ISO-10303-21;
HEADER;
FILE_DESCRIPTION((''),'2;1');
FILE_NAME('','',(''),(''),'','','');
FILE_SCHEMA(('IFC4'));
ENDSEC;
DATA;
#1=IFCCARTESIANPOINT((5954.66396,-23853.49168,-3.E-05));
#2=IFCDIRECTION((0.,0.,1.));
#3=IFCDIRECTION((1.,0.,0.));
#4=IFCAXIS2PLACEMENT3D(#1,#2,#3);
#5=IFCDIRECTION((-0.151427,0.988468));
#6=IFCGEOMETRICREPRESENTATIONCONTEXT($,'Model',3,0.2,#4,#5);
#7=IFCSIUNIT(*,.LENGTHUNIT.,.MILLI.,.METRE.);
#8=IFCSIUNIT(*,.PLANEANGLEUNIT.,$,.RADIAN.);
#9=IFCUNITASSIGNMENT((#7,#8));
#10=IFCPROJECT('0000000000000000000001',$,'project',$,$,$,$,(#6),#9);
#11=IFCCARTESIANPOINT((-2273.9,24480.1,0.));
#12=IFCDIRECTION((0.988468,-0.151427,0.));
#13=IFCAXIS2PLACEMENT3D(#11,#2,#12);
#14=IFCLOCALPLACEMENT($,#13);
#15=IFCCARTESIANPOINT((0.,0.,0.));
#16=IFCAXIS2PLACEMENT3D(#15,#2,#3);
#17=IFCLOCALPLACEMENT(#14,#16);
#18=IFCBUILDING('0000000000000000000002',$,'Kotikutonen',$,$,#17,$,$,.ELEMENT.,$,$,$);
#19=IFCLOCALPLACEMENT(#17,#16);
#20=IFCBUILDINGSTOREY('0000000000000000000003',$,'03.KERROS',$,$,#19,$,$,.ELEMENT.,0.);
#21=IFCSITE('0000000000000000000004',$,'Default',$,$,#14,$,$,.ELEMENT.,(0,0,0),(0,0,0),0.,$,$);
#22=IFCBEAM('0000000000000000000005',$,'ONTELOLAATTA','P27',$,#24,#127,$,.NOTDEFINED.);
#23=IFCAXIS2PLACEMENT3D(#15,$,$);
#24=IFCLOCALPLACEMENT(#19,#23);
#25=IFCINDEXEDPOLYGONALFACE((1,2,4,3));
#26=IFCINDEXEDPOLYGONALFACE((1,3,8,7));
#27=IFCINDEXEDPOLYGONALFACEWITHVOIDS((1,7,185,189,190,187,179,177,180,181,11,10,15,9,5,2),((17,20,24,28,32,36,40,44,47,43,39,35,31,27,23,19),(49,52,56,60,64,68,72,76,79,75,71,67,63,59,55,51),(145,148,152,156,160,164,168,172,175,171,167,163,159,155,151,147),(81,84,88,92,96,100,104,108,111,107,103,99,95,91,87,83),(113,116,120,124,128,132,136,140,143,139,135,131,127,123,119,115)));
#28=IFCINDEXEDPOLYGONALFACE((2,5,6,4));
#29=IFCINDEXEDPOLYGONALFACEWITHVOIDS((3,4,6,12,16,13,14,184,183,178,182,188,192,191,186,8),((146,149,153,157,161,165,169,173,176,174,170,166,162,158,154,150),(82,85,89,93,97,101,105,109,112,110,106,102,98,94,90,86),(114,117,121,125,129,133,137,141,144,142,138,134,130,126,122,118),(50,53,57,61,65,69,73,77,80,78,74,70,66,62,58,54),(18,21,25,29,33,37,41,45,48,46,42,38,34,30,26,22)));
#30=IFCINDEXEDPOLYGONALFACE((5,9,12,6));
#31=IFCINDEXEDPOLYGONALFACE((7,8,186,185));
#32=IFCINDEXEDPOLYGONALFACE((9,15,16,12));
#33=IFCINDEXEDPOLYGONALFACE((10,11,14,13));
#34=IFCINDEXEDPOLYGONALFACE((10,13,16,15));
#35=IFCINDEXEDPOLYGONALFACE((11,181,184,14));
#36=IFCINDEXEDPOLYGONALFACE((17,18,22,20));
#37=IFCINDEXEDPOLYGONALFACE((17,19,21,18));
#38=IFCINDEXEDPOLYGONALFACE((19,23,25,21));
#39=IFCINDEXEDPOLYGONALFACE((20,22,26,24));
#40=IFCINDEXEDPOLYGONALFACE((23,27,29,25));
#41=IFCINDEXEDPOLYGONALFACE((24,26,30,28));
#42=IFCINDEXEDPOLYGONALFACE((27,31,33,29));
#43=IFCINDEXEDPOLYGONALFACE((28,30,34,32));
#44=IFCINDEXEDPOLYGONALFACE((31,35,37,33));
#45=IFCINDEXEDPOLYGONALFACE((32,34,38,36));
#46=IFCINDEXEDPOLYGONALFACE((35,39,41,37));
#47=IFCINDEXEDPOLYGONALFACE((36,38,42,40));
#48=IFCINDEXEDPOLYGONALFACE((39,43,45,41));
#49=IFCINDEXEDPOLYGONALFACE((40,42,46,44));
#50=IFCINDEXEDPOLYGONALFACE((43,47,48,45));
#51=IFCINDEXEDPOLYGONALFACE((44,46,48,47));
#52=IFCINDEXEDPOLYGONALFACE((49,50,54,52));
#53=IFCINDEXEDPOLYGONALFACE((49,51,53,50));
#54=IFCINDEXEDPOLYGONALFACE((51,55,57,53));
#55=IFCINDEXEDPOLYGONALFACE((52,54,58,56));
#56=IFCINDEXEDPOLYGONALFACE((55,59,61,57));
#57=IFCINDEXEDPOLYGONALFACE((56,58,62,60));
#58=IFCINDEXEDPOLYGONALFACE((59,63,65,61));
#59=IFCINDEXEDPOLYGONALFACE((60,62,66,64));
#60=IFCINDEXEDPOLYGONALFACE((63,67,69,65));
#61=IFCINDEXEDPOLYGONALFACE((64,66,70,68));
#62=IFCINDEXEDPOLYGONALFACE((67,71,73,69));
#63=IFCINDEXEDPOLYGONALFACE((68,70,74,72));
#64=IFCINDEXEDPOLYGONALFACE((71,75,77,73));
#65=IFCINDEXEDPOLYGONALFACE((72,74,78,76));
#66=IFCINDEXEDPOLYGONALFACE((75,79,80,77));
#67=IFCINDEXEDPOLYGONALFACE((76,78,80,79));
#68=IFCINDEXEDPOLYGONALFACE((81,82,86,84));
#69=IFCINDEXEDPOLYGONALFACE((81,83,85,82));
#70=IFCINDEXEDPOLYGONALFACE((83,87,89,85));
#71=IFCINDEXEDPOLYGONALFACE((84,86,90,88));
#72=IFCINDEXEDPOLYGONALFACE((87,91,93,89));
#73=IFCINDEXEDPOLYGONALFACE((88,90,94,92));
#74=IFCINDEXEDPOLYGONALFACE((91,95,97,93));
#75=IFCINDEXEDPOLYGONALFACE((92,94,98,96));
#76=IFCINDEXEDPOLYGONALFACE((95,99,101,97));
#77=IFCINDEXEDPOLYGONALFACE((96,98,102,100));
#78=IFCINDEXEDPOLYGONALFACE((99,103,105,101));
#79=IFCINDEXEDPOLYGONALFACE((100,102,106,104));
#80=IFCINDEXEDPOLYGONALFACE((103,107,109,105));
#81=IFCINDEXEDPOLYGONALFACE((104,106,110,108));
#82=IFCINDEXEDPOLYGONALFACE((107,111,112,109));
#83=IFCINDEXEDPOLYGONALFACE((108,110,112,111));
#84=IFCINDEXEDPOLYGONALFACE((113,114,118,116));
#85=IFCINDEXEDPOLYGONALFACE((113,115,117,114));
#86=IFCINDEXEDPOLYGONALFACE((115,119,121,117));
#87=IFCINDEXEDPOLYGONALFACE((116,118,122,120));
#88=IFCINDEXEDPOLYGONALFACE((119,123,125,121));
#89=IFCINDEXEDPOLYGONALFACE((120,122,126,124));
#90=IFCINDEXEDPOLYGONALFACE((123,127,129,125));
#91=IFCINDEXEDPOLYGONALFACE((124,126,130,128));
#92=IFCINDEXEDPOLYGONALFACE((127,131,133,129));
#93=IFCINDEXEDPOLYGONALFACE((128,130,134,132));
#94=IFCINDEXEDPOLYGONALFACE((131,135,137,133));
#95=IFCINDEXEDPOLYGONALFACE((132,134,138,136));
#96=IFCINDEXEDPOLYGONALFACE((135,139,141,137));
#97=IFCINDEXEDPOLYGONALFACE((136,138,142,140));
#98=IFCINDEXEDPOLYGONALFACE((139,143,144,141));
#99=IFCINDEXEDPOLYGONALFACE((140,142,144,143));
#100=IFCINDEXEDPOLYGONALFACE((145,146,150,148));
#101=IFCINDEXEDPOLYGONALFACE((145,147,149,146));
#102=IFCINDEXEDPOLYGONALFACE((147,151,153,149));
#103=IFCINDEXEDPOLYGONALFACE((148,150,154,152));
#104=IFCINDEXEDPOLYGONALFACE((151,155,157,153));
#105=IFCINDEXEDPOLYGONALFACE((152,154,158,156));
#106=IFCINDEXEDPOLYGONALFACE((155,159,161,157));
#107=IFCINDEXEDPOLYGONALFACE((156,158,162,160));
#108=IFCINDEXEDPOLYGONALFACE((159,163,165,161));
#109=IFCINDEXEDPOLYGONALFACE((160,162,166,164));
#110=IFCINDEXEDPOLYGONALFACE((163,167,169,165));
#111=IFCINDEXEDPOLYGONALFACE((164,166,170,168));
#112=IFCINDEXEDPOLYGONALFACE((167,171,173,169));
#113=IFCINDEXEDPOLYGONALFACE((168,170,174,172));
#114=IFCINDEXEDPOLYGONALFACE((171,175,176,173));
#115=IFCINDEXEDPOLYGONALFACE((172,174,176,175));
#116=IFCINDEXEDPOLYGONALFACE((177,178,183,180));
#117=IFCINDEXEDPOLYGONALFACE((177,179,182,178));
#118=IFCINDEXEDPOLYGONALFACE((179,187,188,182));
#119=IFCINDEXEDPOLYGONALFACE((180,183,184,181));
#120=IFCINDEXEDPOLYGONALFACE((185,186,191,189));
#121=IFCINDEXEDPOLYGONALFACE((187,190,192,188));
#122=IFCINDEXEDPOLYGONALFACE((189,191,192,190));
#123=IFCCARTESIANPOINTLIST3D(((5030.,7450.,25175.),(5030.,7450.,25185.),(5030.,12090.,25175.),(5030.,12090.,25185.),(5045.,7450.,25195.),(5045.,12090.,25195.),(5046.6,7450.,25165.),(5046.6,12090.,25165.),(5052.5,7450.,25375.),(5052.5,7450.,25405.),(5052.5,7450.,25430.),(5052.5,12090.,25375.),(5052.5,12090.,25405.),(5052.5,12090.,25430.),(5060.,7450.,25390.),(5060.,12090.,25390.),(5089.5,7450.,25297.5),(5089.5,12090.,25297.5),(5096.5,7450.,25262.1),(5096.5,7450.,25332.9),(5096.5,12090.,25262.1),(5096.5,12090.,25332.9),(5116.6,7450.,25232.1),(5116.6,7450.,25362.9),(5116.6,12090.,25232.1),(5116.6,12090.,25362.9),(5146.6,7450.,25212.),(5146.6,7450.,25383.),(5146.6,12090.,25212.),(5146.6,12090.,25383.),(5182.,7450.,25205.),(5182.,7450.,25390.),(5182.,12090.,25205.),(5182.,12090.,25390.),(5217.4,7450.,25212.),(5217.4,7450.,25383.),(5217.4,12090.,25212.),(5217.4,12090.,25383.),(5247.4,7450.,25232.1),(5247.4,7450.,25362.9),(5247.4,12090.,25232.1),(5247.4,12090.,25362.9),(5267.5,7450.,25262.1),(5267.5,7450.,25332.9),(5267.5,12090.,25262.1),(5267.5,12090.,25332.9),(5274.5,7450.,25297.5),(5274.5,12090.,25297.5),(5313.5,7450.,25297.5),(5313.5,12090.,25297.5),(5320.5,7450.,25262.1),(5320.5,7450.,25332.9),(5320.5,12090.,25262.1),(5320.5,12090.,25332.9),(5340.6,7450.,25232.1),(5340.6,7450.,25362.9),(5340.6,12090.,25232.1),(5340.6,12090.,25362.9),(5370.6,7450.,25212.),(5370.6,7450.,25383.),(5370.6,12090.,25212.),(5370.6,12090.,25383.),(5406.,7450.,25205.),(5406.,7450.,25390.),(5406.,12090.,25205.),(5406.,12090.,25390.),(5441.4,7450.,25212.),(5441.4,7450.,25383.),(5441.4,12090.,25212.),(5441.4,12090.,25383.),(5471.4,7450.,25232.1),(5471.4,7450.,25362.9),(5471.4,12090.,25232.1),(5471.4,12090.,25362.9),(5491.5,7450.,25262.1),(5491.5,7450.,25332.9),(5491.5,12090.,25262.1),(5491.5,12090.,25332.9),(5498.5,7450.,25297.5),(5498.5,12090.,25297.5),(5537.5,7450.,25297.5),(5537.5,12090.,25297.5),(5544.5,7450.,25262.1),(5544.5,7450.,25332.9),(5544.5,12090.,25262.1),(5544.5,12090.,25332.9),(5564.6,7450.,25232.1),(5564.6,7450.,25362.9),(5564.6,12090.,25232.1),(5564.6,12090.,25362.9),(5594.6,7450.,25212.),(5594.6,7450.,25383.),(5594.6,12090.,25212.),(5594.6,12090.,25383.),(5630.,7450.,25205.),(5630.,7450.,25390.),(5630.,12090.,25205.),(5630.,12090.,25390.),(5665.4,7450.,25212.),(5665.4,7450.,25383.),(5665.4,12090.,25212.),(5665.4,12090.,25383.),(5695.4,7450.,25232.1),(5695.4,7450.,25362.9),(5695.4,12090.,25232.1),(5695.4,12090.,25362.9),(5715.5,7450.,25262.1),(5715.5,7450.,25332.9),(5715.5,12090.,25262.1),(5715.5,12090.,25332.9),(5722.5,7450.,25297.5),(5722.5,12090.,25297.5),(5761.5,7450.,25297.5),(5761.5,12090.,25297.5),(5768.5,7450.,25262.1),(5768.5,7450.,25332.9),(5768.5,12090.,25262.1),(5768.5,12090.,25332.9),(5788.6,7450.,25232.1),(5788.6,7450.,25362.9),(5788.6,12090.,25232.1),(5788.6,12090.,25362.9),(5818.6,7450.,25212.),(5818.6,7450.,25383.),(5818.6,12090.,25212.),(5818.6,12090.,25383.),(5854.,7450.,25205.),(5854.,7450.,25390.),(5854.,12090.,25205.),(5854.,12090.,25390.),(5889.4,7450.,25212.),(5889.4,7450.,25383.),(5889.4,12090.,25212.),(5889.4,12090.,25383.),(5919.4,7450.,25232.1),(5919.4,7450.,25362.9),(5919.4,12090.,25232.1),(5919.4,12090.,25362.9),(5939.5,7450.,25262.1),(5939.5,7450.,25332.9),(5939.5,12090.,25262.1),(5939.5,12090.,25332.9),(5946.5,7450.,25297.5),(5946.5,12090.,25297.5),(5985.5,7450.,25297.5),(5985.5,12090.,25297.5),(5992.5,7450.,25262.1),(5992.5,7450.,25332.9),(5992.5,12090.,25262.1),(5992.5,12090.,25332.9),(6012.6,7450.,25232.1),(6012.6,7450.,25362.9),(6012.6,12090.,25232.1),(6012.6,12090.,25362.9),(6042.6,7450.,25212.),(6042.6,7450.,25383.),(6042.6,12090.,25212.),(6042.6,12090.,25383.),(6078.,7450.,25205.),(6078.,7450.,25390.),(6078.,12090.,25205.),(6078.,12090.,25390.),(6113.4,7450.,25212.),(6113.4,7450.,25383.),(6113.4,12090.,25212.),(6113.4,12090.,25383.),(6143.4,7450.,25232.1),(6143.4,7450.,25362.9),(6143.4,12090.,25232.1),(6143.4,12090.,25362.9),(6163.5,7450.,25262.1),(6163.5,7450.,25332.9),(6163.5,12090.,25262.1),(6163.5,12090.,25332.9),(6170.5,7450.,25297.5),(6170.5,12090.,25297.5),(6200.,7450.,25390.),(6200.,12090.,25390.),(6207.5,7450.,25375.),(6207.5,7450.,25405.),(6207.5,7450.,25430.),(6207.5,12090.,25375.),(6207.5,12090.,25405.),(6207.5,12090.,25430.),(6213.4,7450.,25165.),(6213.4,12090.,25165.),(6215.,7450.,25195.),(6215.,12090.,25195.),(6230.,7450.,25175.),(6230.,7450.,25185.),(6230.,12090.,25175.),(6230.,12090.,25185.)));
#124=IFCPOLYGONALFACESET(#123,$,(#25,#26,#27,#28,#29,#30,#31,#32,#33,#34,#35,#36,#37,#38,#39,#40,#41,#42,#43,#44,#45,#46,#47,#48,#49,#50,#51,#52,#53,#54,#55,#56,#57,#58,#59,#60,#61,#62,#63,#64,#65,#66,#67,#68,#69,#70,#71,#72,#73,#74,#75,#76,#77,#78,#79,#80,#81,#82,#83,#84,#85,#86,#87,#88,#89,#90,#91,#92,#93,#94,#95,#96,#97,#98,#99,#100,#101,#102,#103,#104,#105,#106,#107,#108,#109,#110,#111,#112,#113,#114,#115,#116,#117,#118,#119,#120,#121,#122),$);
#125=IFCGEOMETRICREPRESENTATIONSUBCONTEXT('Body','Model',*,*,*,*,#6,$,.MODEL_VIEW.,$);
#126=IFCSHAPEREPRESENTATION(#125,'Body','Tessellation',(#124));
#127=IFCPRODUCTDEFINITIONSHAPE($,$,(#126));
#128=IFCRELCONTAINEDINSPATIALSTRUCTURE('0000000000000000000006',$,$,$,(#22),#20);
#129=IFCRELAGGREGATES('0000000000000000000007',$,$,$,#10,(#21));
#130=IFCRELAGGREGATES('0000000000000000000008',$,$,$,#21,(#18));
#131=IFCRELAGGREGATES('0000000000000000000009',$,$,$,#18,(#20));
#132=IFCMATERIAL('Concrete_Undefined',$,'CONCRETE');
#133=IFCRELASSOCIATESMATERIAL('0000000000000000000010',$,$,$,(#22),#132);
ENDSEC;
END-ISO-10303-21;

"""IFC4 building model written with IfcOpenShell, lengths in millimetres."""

from ifc_helpers import new_model, si_unit, direction, frame, origin_with_axes, place, context, subcontext, project, spatial, line, indexed_curve, outline, extrude, material, element, save


model = new_model("IFC4")

# Units and contexts
model_context = context("Model", 3, precision=0.2, world=frame((5954.66396, -23853.49168, -3e-05), z_axis=(0.0, 0.0, 1.0), x_axis=(1.0, 0.0, 0.0)), true_north=direction((-0.151427, 0.988468)))
body_context = subcontext(model_context, "Body", "Model", "MODEL_VIEW")
ifc_project = project(units=[si_unit("LENGTHUNIT", "METRE", prefix="MILLI"), si_unit("PLANEANGLEUNIT", "RADIAN")], contexts=[model_context])

# Site, building, storey
site_placement = place(None, frame((-2273.9, 24480.1, 0.0), z_axis=(0.0, 0.0, 1.0), x_axis=(0.988468, -0.151427, 0.0)))
site = spatial("IfcSite", under=ifc_project, at=site_placement, Name="Default", CompositionType="ELEMENT", RefLatitude=(0, 0, 0), RefLongitude=(0, 0, 0), RefElevation=0.0)
building_placement = place(site_placement, origin_with_axes())
building = spatial("IfcBuilding", under=site, at=building_placement, Name="Kotikutonen", CompositionType="ELEMENT")
storey_placement = place(building_placement, origin_with_axes())
storey = spatial("IfcBuildingStorey", under=building, at=storey_placement, Name="03.KERROS", CompositionType="ELEMENT", Elevation=0.0)

# Shared definitions
ifc_material_1 = material(Name="Concrete_Undefined", Category="CONCRETE")

# Beam
beam_1_placement = place(storey_placement, frame((5630.0, 12090.0, 25297.5), z_axis=(-1.0, 0.0, 0.0), x_axis=(0.0, -1.0, 0.0)))
element("IfcBeam", 1, at=beam_1_placement, inside=storey, material=ifc_material_1, Name="ONTELOLAATTA", Description="P27", PredefinedType="NOTDEFINED", context=body_context, shape_type="SolidModel", body=[
    extrude(outline(indexed_curve([(-600.0, -122.5), (-583.4, -132.5), (583.4, -132.5), (600.0, -122.5), (600.0, -112.5), (585.0, -102.5), (577.5, 77.5), (570.0, 92.5), (577.5, 107.5), (577.5, 132.5), (-577.5, 132.5), (-577.5, 107.5), (-570.0, 92.5), (-577.5, 77.5), (-585.0, -102.5), (-600.0, -112.5)], segments=[line(1, 2, 3, 4, 5, 6, 7, 8, 9, 10, 11, 12, 13, 14, 15, 16, 1)]), holes=[indexed_curve([(-448.0, -92.5), (-483.4, -85.5), (-513.4, -65.4), (-533.5, -35.4), (-540.5, 0.0), (-533.5, 35.4), (-513.4, 65.4), (-483.4, 85.5), (-448.0, 92.5), (-412.6, 85.5), (-382.6, 65.4), (-362.5, 35.4), (-355.5, 0.0), (-362.5, -35.4), (-382.6, -65.4), (-412.6, -85.5)], segments=[line(1, 2, 3, 4, 5, 6, 7, 8, 9, 10, 11, 12, 13, 14, 15, 16, 1)]), indexed_curve([(-224.0, -92.5), (-259.4, -85.5), (-289.4, -65.4), (-309.5, -35.4), (-316.5, 0.0), (-309.5, 35.4), (-289.4, 65.4), (-259.4, 85.5), (-224.0, 92.5), (-188.6, 85.5), (-158.6, 65.4), (-138.5, 35.4), (-131.5, 0.0), (-138.5, -35.4), (-158.6, -65.4), (-188.6, -85.5)], segments=[line(1, 2, 3, 4, 5, 6, 7, 8, 9, 10, 11, 12, 13, 14, 15, 16, 1)]), indexed_curve([(0.0, -92.5), (-35.4, -85.5), (-65.4, -65.4), (-85.5, -35.4), (-92.5, 0.0), (-85.5, 35.4), (-65.4, 65.4), (-35.4, 85.5), (0.0, 92.5), (35.4, 85.5), (65.4, 65.4), (85.5, 35.4), (92.5, 0.0), (85.5, -35.4), (65.4, -65.4), (35.4, -85.5)], segments=[line(1, 2, 3, 4, 5, 6, 7, 8, 9, 10, 11, 12, 13, 14, 15, 16, 1)]), indexed_curve([(224.0, -92.5), (188.6, -85.5), (158.6, -65.4), (138.5, -35.4), (131.5, 0.0), (138.5, 35.4), (158.6, 65.4), (188.6, 85.5), (224.0, 92.5), (259.4, 85.5), (289.4, 65.4), (309.5, 35.4), (316.5, 0.0), (309.5, -35.4), (289.4, -65.4), (259.4, -85.5)], segments=[line(1, 2, 3, 4, 5, 6, 7, 8, 9, 10, 11, 12, 13, 14, 15, 16, 1)]), indexed_curve([(448.0, -92.5), (412.6, -85.5), (382.6, -65.4), (362.5, -35.4), (355.5, 0.0), (362.5, 35.4), (382.6, 65.4), (412.6, 85.5), (448.0, 92.5), (483.4, 85.5), (513.4, 65.4), (533.5, 35.4), (540.5, 0.0), (533.5, -35.4), (513.4, -65.4), (483.4, -85.5)], segments=[line(1, 2, 3, 4, 5, 6, 7, 8, 9, 10, 11, 12, 13, 14, 15, 16, 1)])]), frame((0.0, 0.0, 0.0), z_axis=(-1.0, 0.0, 0.0), x_axis=(0.0, 0.0, 1.0)), (0.0, 0.0, -1.0), 4640.0),
])

save(model, "model.ifc")
